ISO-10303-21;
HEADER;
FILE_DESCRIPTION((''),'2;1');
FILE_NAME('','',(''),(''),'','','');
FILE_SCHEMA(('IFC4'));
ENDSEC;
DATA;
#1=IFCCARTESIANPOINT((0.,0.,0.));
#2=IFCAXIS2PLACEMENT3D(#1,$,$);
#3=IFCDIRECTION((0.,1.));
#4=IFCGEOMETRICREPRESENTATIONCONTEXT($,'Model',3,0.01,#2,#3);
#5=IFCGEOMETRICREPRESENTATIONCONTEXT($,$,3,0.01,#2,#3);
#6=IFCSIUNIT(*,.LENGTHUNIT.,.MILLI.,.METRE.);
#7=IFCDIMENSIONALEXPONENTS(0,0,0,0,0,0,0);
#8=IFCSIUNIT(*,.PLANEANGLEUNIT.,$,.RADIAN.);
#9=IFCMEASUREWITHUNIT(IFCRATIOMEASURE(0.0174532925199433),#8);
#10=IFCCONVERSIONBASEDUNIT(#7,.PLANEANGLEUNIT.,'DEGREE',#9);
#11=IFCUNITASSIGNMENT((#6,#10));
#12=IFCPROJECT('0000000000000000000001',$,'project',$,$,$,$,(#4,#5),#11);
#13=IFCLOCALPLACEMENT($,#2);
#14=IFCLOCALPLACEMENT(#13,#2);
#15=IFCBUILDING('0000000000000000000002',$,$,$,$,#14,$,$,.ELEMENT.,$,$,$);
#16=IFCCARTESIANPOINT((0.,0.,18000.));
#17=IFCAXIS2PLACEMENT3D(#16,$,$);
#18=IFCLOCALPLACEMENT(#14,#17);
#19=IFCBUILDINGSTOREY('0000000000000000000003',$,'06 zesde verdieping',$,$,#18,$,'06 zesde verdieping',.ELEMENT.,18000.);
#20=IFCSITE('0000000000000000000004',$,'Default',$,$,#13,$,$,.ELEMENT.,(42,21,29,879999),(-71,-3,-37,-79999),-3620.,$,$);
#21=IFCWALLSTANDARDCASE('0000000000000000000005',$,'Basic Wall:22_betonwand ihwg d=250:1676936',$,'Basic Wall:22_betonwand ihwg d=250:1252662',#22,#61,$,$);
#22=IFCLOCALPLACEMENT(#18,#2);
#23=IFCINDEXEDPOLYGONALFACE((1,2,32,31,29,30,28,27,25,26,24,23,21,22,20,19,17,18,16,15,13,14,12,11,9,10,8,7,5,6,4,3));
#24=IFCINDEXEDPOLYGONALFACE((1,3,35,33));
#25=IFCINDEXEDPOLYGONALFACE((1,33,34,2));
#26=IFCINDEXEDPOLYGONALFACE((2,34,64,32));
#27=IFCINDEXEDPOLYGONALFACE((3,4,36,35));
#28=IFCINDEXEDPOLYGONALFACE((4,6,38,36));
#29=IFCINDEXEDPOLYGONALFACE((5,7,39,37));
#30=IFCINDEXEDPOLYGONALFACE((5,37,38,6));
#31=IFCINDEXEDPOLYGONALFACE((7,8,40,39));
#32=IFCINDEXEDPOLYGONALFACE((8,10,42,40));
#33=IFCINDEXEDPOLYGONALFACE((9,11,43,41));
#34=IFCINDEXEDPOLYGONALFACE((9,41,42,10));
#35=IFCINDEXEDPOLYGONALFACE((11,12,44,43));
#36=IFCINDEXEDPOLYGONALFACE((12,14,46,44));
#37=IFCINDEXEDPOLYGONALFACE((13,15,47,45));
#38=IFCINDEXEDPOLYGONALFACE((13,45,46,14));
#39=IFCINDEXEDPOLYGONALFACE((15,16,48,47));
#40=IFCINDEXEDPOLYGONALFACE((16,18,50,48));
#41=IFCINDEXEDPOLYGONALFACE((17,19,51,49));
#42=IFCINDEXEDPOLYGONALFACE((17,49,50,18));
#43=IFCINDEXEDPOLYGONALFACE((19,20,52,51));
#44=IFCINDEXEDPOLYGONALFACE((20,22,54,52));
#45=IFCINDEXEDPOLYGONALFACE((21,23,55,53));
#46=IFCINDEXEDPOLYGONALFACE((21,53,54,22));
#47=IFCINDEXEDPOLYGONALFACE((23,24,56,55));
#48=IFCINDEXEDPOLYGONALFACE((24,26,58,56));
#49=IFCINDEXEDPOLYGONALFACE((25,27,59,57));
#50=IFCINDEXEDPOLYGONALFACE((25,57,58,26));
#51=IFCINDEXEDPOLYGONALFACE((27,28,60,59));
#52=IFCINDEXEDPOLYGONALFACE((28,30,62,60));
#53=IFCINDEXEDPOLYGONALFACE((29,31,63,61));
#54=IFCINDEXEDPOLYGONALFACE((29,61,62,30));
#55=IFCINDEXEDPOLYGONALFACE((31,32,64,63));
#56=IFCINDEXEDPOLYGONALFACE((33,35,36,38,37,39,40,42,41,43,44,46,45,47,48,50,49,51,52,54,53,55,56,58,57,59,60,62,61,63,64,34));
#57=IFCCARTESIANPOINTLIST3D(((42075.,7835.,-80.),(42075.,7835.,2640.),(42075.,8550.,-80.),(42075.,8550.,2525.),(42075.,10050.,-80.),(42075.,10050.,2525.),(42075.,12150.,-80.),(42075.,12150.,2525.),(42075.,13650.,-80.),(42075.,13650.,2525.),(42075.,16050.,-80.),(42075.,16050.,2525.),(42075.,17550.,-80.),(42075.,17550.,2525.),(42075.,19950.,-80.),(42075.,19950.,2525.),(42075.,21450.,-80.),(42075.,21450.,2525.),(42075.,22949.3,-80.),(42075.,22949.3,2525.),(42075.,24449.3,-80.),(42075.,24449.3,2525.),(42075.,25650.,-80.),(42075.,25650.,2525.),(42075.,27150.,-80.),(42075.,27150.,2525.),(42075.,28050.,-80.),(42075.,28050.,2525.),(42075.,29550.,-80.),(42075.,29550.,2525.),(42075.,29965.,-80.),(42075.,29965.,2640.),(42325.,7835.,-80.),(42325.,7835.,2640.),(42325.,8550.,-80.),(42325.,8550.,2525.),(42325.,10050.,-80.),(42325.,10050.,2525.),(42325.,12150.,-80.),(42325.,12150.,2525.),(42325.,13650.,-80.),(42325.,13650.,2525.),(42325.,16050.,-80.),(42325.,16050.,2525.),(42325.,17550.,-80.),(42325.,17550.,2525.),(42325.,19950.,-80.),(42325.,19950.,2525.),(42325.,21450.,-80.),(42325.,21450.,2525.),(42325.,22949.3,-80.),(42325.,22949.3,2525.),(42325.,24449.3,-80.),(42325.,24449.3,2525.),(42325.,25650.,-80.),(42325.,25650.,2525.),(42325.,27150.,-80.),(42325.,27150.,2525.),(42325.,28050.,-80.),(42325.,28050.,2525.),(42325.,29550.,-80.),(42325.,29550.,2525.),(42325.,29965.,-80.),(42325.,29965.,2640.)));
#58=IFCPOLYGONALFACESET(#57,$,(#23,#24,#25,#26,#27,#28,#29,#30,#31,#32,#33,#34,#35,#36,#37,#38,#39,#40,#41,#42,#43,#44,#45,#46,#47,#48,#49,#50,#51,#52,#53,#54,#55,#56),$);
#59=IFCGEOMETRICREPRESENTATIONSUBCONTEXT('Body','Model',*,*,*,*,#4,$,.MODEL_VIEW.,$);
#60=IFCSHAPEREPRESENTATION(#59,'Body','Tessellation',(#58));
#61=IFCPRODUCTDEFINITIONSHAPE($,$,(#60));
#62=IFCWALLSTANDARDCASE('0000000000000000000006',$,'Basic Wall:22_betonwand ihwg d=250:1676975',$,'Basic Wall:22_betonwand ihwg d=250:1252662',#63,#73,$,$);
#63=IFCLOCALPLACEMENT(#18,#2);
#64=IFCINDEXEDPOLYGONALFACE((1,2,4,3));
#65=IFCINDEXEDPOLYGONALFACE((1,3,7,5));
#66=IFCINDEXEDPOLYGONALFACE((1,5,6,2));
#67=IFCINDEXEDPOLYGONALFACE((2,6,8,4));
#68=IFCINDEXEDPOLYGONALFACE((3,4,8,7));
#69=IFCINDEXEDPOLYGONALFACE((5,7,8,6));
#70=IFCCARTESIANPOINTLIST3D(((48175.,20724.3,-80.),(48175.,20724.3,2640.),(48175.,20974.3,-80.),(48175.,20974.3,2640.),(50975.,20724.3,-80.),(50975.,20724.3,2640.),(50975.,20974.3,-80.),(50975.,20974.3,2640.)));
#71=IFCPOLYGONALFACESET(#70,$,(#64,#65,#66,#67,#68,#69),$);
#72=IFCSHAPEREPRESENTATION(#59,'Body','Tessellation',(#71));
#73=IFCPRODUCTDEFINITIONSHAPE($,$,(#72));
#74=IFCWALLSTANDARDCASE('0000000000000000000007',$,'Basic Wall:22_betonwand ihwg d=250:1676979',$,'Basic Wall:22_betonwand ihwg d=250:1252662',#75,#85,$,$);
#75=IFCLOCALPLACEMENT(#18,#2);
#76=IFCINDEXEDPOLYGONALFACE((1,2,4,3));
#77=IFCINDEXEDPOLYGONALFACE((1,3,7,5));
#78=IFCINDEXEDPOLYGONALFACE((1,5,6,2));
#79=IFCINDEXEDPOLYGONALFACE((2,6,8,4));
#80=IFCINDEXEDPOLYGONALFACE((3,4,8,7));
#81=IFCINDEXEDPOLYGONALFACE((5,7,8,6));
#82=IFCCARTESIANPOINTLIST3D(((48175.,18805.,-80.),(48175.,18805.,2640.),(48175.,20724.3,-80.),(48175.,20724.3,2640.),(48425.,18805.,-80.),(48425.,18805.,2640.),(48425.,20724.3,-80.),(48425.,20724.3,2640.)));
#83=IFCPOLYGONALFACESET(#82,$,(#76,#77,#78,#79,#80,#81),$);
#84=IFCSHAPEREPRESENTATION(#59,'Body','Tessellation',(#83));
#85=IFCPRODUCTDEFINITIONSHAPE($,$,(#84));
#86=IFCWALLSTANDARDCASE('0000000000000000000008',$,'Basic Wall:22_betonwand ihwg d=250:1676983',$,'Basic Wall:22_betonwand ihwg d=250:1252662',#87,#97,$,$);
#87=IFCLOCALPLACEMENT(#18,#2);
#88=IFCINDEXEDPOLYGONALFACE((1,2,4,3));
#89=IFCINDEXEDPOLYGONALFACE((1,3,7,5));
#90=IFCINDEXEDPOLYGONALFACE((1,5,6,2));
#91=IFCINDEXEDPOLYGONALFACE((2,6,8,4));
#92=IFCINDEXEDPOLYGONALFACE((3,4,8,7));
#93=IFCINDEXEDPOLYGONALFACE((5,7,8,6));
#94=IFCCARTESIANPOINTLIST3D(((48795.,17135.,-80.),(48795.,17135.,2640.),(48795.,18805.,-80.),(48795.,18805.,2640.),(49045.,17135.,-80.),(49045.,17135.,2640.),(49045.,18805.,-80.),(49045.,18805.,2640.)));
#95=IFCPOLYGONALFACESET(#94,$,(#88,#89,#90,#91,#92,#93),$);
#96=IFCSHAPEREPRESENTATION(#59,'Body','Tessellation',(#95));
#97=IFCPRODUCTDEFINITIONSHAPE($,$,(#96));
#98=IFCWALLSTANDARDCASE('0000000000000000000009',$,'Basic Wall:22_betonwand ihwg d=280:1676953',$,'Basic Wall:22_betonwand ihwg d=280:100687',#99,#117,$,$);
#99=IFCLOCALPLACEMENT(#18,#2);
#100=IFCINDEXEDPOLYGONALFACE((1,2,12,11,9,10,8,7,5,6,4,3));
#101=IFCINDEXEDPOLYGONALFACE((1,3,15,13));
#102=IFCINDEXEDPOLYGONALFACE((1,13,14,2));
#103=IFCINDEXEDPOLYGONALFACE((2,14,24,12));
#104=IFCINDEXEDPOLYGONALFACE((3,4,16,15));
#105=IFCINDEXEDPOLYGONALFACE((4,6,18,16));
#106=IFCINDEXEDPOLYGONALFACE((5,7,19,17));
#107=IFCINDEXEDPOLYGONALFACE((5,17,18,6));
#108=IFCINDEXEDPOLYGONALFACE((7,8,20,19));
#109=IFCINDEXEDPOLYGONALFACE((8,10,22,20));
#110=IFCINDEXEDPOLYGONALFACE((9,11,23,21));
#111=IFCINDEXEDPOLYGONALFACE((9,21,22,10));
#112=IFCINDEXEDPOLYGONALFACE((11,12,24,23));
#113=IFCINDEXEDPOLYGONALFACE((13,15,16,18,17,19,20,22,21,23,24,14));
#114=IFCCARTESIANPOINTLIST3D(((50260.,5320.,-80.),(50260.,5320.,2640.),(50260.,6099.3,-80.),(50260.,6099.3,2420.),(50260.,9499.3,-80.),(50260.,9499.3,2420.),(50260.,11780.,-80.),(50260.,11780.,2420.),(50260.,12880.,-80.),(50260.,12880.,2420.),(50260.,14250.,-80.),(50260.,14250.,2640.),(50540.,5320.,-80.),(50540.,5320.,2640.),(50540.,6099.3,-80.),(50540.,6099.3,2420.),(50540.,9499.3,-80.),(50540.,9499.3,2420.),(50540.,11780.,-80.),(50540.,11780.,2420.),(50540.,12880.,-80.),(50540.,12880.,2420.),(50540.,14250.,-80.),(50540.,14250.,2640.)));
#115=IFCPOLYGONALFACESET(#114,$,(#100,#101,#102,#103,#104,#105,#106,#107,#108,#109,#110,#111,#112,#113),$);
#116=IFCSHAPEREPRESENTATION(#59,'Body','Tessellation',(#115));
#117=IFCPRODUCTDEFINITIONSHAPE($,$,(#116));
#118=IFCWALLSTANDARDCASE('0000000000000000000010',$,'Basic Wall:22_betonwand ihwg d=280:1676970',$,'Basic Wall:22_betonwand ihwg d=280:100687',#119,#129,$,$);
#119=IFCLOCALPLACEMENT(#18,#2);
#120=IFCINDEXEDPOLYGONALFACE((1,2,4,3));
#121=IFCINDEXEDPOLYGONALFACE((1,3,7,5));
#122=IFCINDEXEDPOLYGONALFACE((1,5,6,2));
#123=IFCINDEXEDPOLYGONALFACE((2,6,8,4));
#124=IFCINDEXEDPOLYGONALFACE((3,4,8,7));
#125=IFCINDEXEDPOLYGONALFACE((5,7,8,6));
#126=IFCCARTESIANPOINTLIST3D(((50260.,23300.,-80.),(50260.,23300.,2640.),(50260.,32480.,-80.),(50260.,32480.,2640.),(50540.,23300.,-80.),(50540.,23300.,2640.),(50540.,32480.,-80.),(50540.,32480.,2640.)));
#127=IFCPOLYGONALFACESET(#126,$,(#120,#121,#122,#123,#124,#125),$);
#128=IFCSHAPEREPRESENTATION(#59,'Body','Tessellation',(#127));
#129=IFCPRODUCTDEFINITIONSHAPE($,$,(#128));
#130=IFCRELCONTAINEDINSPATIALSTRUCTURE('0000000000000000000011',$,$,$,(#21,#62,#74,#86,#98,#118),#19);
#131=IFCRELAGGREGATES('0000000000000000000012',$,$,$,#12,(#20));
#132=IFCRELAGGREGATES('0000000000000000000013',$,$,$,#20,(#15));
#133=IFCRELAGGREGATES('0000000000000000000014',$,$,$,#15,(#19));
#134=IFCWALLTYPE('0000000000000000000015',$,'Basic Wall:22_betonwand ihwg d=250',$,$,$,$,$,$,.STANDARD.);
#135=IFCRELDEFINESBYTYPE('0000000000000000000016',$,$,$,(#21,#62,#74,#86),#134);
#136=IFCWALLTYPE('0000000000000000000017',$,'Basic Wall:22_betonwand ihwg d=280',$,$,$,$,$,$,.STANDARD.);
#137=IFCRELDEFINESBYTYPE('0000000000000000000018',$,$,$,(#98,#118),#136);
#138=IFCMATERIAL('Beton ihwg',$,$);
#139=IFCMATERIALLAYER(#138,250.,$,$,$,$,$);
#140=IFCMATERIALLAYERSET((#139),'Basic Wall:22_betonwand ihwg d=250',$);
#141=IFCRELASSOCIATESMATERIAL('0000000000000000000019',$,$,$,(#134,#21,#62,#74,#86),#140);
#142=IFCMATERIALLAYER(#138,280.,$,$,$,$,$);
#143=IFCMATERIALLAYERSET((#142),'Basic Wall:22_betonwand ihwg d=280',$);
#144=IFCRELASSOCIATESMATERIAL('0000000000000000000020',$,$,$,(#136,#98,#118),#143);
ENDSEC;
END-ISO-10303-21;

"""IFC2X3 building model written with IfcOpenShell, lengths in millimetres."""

from ifc_helpers import new_model, entity, si_unit, converted_unit, direction, frame, frame_2d, origin, place, context, subcontext, project, spatial, rectangle, extrude, material, layer, layer_set, layer_usage, type_object, element, save


model = new_model("IFC2X3")

# Units and contexts
model_context = context("Model", 3, precision=0.01, world=origin(), true_north=direction((0.0, 1.0)))
context_of_model = context(None, 3, precision=0.01, world=origin(), true_north=direction((0.0, 1.0)))
body_context = subcontext(model_context, "Body", "Model", "MODEL_VIEW")
ifc_project = project(units=[si_unit("LENGTHUNIT", "METRE", prefix="MILLI"), converted_unit("PLANEANGLEUNIT", "DEGREE", entity("IfcRatioMeasure", 0.0174532925199433), si_unit("PLANEANGLEUNIT", "RADIAN"), dimensions=[0, 0, 0, 0, 0, 0, 0])], contexts=[model_context, context_of_model])

# Site, building, storey
site_placement = place(None, origin())
site = spatial("IfcSite", under=ifc_project, at=site_placement, Name="Default", CompositionType="ELEMENT", RefLatitude=(42, 21, 29, 879999), RefLongitude=(-71, -3, -37, -79999), RefElevation=-3620.0)
building_placement = place(site_placement, origin())
building = spatial("IfcBuilding", under=site, at=building_placement, CompositionType="ELEMENT")
storey_placement = place(building_placement, frame((0.0, 0.0, 18000.0)))
storey = spatial("IfcBuildingStorey", under=building, at=storey_placement, Name="06 zesde verdieping", LongName="06 zesde verdieping", CompositionType="ELEMENT", Elevation=18000.0)

# Shared definitions
ifc_material_1 = material(Name="Beton ihwg")

# Wall, openings
ifc_layer_1 = layer(ifc_material_1, 250.0)
ifc_layer_set_1 = layer_set([ifc_layer_1], Name="Basic Wall:22_betonwand ihwg d=250")
ifc_layer_usage_1 = layer_usage(ifc_layer_set_1, "AXIS2", "POSITIVE", -125.0)
wall_type_1 = type_object("IfcWallType", Name="Basic Wall:22_betonwand ihwg d=250", PredefinedType="STANDARD", material=ifc_layer_set_1)
wall_1_placement = place(storey_placement, frame((42200.0, 29965.0, -80.0), z_axis=(0.0, 0.0, 1.0), x_axis=(0.0, -1.0, 0.0)))
wall_1 = element("IfcWallStandardCase", 1, at=wall_1_placement, inside=storey, type_object=wall_type_1, material=ifc_layer_usage_1, Name="Basic Wall:22_betonwand ihwg d=250:1676936", ObjectType="Basic Wall:22_betonwand ihwg d=250:1252662", context=body_context, shape_type="SweptSolid", body=[
    extrude(rectangle(XDim=22130.0, YDim=250.0, at=frame_2d((11065.0, 0.0), x_axis=(-1.0, 0.0))), origin(), (0.0, 0.0, 1.0), 2720.0),
])
opening_1_placement = place(wall_1_placement, frame((29965.0, -42200.0, 80.0), z_axis=(0.0, 0.0, 1.0), x_axis=(0.0, 1.0, 0.0)))
element("IfcOpeningElement", 2, at=opening_1_placement, cuts=wall_1, ObjectType="Opening", context=body_context, shape_type="SweptSolid", body=[
    extrude(rectangle(XDim=2605.0, YDim=1500.0, at=frame_2d((0.0, 0.0), x_axis=(1.0, 0.0))), frame((40801.0, 28800.0, 1222.5), z_axis=(1.0, 0.0, 0.0), x_axis=(0.0, 0.0, -1.0)), (0.0, 0.0, 1.0), 3048.0),
])
opening_2_placement = place(wall_1_placement, frame((29965.0, -42200.0, 80.0), z_axis=(0.0, 0.0, 1.0), x_axis=(0.0, 1.0, 0.0)))
element("IfcOpeningElement", 3, at=opening_2_placement, cuts=wall_1, ObjectType="Opening", context=body_context, shape_type="SweptSolid", body=[
    extrude(rectangle(XDim=2605.0, YDim=1500.0, at=frame_2d((0.0, 0.0), x_axis=(1.0, 0.0))), frame((40801.0, 26400.0, 1222.5), z_axis=(1.0, 0.0, 0.0), x_axis=(0.0, 0.0, -1.0)), (0.0, 0.0, 1.0), 3048.0),
])
opening_3_placement = place(wall_1_placement, frame((29965.0, -42200.0, 80.0), z_axis=(0.0, 0.0, 1.0), x_axis=(0.0, 1.0, 0.0)))
element("IfcOpeningElement", 4, at=opening_3_placement, cuts=wall_1, ObjectType="Opening", context=body_context, shape_type="SweptSolid", body=[
    extrude(rectangle(XDim=2605.0, YDim=1500.0, at=frame_2d((0.0, 0.0), x_axis=(1.0, 0.0))), frame((40801.0, 23699.3, 1222.5), z_axis=(1.0, 0.0, 0.0), x_axis=(0.0, 0.0, -1.0)), (0.0, 0.0, 1.0), 3048.0),
])
opening_4_placement = place(wall_1_placement, frame((29965.0, -42200.0, 80.0), z_axis=(0.0, 0.0, 1.0), x_axis=(0.0, 1.0, 0.0)))
element("IfcOpeningElement", 5, at=opening_4_placement, cuts=wall_1, ObjectType="Opening", context=body_context, shape_type="SweptSolid", body=[
    extrude(rectangle(XDim=2605.0, YDim=1500.0, at=frame_2d((0.0, 0.0), x_axis=(1.0, 0.0))), frame((40801.0, 20700.0, 1222.5), z_axis=(1.0, 0.0, 0.0), x_axis=(0.0, 0.0, -1.0)), (0.0, 0.0, 1.0), 3048.0),
])
opening_5_placement = place(wall_1_placement, frame((29965.0, -42200.0, 80.0), z_axis=(0.0, 0.0, 1.0), x_axis=(0.0, 1.0, 0.0)))
element("IfcOpeningElement", 6, at=opening_5_placement, cuts=wall_1, ObjectType="Opening", context=body_context, shape_type="SweptSolid", body=[
    extrude(rectangle(XDim=2605.0, YDim=1500.0, at=frame_2d((0.0, 0.0), x_axis=(1.0, 0.0))), frame((40801.0, 12900.0, 1222.5), z_axis=(1.0, 0.0, 0.0), x_axis=(0.0, 0.0, -1.0)), (0.0, 0.0, 1.0), 3048.0),
])
opening_6_placement = place(wall_1_placement, frame((29965.0, -42200.0, -2920.0), z_axis=(0.0, 0.0, 1.0), x_axis=(0.0, 1.0, 0.0)))
element("IfcOpeningElement", 7, at=opening_6_placement, cuts=wall_1, ObjectType="Opening", context=body_context, shape_type="SweptSolid", body=[
    extrude(rectangle(XDim=2605.0, YDim=1500.0, at=frame_2d((0.0, 0.0), x_axis=(1.0, 0.0))), frame((40801.0, 9300.0, 4222.5), z_axis=(1.0, 0.0, 0.0), x_axis=(0.0, 0.0, -1.0)), (0.0, 0.0, 1.0), 3048.0),
])
opening_7_placement = place(wall_1_placement, frame((29965.0, -42200.0, 80.0), z_axis=(0.0, 0.0, 1.0), x_axis=(0.0, 1.0, 0.0)))
element("IfcOpeningElement", 8, at=opening_7_placement, cuts=wall_1, ObjectType="Opening", context=body_context, shape_type="SweptSolid", body=[
    extrude(rectangle(XDim=2605.0, YDim=1500.0, at=frame_2d((0.0, 0.0), x_axis=(0.0, 1.0))), frame((40551.0, 16800.0, 1222.5), z_axis=(1.0, 0.0, 0.0), x_axis=(0.0, -1.0, 0.0)), (0.0, 0.0, 1.0), 3048.0),
])

# Walls
ifc_layer_usage_2 = layer_usage(ifc_layer_set_1, "AXIS2", "POSITIVE", -125.0)
wall_2_placement = place(storey_placement, frame((50975.0, 20849.3, -80.0), z_axis=(0.0, 0.0, 1.0), x_axis=(-1.0, 0.0, 0.0)))
element("IfcWallStandardCase", 9, at=wall_2_placement, inside=storey, type_object=wall_type_1, material=ifc_layer_usage_2, Name="Basic Wall:22_betonwand ihwg d=250:1676975", ObjectType="Basic Wall:22_betonwand ihwg d=250:1252662", context=body_context, shape_type="SweptSolid", body=[
    extrude(rectangle(XDim=2800.0, YDim=250.0, at=frame_2d((1400.0, 0.0), x_axis=(-1.0, 0.0))), origin(), (0.0, 0.0, 1.0), 2720.0),
])
ifc_layer_usage_3 = layer_usage(ifc_layer_set_1, "AXIS2", "POSITIVE", -125.0)
wall_3_placement = place(storey_placement, frame((48300.0, 20724.3, -80.0), z_axis=(0.0, 0.0, 1.0), x_axis=(0.0, -1.0, 0.0)))
element("IfcWallStandardCase", 10, at=wall_3_placement, inside=storey, type_object=wall_type_1, material=ifc_layer_usage_3, Name="Basic Wall:22_betonwand ihwg d=250:1676979", ObjectType="Basic Wall:22_betonwand ihwg d=250:1252662", context=body_context, shape_type="SweptSolid", body=[
    extrude(rectangle(XDim=1919.3, YDim=250.0, at=frame_2d((959.6, 0.0), x_axis=(-1.0, 0.0))), origin(), (0.0, 0.0, 1.0), 2720.0),
])
ifc_layer_usage_4 = layer_usage(ifc_layer_set_1, "AXIS2", "POSITIVE", -125.0)
wall_4_placement = place(storey_placement, frame((48920.0, 18805.0, -80.0), z_axis=(0.0, 0.0, 1.0), x_axis=(0.0, -1.0, 0.0)))
element("IfcWallStandardCase", 11, at=wall_4_placement, inside=storey, type_object=wall_type_1, material=ifc_layer_usage_4, Name="Basic Wall:22_betonwand ihwg d=250:1676983", ObjectType="Basic Wall:22_betonwand ihwg d=250:1252662", context=body_context, shape_type="SweptSolid", body=[
    extrude(rectangle(XDim=1670.0, YDim=250.0, at=frame_2d((835.0, 0.0), x_axis=(-1.0, 0.0))), origin(), (0.0, 0.0, 1.0), 2720.0),
])

# Wall, openings
ifc_layer_2 = layer(ifc_material_1, 280.0)
ifc_layer_set_2 = layer_set([ifc_layer_2], Name="Basic Wall:22_betonwand ihwg d=280")
ifc_layer_usage_5 = layer_usage(ifc_layer_set_2, "AXIS2", "NEGATIVE", 140.0)
wall_type_2 = type_object("IfcWallType", Name="Basic Wall:22_betonwand ihwg d=280", PredefinedType="STANDARD", material=ifc_layer_set_2)
wall_5_placement = place(storey_placement, frame((50400.0, 14250.0, -80.0), z_axis=(0.0, 0.0, 1.0), x_axis=(0.0, -1.0, 0.0)))
wall_5 = element("IfcWallStandardCase", 12, at=wall_5_placement, inside=storey, type_object=wall_type_2, material=ifc_layer_usage_5, Name="Basic Wall:22_betonwand ihwg d=280:1676953", ObjectType="Basic Wall:22_betonwand ihwg d=280:100687", context=body_context, shape_type="SweptSolid", body=[
    extrude(rectangle(XDim=8930.0, YDim=280.0, at=frame_2d((4465.0, 0.0), x_axis=(-1.0, 0.0))), origin(), (0.0, 0.0, 1.0), 2720.0),
])
opening_8_placement = place(wall_5_placement, frame((14250.0, -50400.0, 80.0), z_axis=(0.0, 0.0, 1.0), x_axis=(0.0, 1.0, 0.0)))
element("IfcOpeningElement", 13, at=opening_8_placement, cuts=wall_5, ObjectType="Opening", context=body_context, shape_type="SweptSolid", body=[
    extrude(rectangle(XDim=2500.0, YDim=3400.0, at=frame_2d((0.0, 0.0), x_axis=(1.0, 0.0))), frame((50000.0, 7799.3, 1170.0), z_axis=(1.0, 0.0, 0.0), x_axis=(0.0, 0.0, -1.0)), (0.0, 0.0, 1.0), 800.0),
])
opening_9_placement = place(wall_5_placement, frame((14250.0, -50400.0, 80.0), z_axis=(0.0, 0.0, 1.0), x_axis=(0.0, 1.0, 0.0)))
element("IfcOpeningElement", 14, at=opening_9_placement, cuts=wall_5, ObjectType="Opening", context=body_context, shape_type="SweptSolid", body=[
    extrude(rectangle(XDim=2500.0, YDim=1100.0, at=frame_2d((0.0, 0.0), x_axis=(1.0, 0.0))), frame((50000.0, 12330.0, 1170.0), z_axis=(1.0, 0.0, 0.0), x_axis=(0.0, 0.0, -1.0)), (0.0, 0.0, 1.0), 800.0),
])

# Wall
ifc_layer_usage_6 = layer_usage(ifc_layer_set_2, "AXIS2", "POSITIVE", -140.0)
wall_6_placement = place(storey_placement, frame((50400.0, 23300.0, -80.0), z_axis=(0.0, 0.0, 1.0), x_axis=(0.0, 1.0, 0.0)))
element("IfcWallStandardCase", 15, at=wall_6_placement, inside=storey, type_object=wall_type_2, material=ifc_layer_usage_6, Name="Basic Wall:22_betonwand ihwg d=280:1676970", ObjectType="Basic Wall:22_betonwand ihwg d=280:100687", context=body_context, shape_type="SweptSolid", body=[
    extrude(rectangle(XDim=9180.0, YDim=280.0, at=frame_2d((4590.0, 0.0), x_axis=(-1.0, 0.0))), origin(), (0.0, 0.0, 1.0), 2720.0),
])

save(model, "model.ifc")
